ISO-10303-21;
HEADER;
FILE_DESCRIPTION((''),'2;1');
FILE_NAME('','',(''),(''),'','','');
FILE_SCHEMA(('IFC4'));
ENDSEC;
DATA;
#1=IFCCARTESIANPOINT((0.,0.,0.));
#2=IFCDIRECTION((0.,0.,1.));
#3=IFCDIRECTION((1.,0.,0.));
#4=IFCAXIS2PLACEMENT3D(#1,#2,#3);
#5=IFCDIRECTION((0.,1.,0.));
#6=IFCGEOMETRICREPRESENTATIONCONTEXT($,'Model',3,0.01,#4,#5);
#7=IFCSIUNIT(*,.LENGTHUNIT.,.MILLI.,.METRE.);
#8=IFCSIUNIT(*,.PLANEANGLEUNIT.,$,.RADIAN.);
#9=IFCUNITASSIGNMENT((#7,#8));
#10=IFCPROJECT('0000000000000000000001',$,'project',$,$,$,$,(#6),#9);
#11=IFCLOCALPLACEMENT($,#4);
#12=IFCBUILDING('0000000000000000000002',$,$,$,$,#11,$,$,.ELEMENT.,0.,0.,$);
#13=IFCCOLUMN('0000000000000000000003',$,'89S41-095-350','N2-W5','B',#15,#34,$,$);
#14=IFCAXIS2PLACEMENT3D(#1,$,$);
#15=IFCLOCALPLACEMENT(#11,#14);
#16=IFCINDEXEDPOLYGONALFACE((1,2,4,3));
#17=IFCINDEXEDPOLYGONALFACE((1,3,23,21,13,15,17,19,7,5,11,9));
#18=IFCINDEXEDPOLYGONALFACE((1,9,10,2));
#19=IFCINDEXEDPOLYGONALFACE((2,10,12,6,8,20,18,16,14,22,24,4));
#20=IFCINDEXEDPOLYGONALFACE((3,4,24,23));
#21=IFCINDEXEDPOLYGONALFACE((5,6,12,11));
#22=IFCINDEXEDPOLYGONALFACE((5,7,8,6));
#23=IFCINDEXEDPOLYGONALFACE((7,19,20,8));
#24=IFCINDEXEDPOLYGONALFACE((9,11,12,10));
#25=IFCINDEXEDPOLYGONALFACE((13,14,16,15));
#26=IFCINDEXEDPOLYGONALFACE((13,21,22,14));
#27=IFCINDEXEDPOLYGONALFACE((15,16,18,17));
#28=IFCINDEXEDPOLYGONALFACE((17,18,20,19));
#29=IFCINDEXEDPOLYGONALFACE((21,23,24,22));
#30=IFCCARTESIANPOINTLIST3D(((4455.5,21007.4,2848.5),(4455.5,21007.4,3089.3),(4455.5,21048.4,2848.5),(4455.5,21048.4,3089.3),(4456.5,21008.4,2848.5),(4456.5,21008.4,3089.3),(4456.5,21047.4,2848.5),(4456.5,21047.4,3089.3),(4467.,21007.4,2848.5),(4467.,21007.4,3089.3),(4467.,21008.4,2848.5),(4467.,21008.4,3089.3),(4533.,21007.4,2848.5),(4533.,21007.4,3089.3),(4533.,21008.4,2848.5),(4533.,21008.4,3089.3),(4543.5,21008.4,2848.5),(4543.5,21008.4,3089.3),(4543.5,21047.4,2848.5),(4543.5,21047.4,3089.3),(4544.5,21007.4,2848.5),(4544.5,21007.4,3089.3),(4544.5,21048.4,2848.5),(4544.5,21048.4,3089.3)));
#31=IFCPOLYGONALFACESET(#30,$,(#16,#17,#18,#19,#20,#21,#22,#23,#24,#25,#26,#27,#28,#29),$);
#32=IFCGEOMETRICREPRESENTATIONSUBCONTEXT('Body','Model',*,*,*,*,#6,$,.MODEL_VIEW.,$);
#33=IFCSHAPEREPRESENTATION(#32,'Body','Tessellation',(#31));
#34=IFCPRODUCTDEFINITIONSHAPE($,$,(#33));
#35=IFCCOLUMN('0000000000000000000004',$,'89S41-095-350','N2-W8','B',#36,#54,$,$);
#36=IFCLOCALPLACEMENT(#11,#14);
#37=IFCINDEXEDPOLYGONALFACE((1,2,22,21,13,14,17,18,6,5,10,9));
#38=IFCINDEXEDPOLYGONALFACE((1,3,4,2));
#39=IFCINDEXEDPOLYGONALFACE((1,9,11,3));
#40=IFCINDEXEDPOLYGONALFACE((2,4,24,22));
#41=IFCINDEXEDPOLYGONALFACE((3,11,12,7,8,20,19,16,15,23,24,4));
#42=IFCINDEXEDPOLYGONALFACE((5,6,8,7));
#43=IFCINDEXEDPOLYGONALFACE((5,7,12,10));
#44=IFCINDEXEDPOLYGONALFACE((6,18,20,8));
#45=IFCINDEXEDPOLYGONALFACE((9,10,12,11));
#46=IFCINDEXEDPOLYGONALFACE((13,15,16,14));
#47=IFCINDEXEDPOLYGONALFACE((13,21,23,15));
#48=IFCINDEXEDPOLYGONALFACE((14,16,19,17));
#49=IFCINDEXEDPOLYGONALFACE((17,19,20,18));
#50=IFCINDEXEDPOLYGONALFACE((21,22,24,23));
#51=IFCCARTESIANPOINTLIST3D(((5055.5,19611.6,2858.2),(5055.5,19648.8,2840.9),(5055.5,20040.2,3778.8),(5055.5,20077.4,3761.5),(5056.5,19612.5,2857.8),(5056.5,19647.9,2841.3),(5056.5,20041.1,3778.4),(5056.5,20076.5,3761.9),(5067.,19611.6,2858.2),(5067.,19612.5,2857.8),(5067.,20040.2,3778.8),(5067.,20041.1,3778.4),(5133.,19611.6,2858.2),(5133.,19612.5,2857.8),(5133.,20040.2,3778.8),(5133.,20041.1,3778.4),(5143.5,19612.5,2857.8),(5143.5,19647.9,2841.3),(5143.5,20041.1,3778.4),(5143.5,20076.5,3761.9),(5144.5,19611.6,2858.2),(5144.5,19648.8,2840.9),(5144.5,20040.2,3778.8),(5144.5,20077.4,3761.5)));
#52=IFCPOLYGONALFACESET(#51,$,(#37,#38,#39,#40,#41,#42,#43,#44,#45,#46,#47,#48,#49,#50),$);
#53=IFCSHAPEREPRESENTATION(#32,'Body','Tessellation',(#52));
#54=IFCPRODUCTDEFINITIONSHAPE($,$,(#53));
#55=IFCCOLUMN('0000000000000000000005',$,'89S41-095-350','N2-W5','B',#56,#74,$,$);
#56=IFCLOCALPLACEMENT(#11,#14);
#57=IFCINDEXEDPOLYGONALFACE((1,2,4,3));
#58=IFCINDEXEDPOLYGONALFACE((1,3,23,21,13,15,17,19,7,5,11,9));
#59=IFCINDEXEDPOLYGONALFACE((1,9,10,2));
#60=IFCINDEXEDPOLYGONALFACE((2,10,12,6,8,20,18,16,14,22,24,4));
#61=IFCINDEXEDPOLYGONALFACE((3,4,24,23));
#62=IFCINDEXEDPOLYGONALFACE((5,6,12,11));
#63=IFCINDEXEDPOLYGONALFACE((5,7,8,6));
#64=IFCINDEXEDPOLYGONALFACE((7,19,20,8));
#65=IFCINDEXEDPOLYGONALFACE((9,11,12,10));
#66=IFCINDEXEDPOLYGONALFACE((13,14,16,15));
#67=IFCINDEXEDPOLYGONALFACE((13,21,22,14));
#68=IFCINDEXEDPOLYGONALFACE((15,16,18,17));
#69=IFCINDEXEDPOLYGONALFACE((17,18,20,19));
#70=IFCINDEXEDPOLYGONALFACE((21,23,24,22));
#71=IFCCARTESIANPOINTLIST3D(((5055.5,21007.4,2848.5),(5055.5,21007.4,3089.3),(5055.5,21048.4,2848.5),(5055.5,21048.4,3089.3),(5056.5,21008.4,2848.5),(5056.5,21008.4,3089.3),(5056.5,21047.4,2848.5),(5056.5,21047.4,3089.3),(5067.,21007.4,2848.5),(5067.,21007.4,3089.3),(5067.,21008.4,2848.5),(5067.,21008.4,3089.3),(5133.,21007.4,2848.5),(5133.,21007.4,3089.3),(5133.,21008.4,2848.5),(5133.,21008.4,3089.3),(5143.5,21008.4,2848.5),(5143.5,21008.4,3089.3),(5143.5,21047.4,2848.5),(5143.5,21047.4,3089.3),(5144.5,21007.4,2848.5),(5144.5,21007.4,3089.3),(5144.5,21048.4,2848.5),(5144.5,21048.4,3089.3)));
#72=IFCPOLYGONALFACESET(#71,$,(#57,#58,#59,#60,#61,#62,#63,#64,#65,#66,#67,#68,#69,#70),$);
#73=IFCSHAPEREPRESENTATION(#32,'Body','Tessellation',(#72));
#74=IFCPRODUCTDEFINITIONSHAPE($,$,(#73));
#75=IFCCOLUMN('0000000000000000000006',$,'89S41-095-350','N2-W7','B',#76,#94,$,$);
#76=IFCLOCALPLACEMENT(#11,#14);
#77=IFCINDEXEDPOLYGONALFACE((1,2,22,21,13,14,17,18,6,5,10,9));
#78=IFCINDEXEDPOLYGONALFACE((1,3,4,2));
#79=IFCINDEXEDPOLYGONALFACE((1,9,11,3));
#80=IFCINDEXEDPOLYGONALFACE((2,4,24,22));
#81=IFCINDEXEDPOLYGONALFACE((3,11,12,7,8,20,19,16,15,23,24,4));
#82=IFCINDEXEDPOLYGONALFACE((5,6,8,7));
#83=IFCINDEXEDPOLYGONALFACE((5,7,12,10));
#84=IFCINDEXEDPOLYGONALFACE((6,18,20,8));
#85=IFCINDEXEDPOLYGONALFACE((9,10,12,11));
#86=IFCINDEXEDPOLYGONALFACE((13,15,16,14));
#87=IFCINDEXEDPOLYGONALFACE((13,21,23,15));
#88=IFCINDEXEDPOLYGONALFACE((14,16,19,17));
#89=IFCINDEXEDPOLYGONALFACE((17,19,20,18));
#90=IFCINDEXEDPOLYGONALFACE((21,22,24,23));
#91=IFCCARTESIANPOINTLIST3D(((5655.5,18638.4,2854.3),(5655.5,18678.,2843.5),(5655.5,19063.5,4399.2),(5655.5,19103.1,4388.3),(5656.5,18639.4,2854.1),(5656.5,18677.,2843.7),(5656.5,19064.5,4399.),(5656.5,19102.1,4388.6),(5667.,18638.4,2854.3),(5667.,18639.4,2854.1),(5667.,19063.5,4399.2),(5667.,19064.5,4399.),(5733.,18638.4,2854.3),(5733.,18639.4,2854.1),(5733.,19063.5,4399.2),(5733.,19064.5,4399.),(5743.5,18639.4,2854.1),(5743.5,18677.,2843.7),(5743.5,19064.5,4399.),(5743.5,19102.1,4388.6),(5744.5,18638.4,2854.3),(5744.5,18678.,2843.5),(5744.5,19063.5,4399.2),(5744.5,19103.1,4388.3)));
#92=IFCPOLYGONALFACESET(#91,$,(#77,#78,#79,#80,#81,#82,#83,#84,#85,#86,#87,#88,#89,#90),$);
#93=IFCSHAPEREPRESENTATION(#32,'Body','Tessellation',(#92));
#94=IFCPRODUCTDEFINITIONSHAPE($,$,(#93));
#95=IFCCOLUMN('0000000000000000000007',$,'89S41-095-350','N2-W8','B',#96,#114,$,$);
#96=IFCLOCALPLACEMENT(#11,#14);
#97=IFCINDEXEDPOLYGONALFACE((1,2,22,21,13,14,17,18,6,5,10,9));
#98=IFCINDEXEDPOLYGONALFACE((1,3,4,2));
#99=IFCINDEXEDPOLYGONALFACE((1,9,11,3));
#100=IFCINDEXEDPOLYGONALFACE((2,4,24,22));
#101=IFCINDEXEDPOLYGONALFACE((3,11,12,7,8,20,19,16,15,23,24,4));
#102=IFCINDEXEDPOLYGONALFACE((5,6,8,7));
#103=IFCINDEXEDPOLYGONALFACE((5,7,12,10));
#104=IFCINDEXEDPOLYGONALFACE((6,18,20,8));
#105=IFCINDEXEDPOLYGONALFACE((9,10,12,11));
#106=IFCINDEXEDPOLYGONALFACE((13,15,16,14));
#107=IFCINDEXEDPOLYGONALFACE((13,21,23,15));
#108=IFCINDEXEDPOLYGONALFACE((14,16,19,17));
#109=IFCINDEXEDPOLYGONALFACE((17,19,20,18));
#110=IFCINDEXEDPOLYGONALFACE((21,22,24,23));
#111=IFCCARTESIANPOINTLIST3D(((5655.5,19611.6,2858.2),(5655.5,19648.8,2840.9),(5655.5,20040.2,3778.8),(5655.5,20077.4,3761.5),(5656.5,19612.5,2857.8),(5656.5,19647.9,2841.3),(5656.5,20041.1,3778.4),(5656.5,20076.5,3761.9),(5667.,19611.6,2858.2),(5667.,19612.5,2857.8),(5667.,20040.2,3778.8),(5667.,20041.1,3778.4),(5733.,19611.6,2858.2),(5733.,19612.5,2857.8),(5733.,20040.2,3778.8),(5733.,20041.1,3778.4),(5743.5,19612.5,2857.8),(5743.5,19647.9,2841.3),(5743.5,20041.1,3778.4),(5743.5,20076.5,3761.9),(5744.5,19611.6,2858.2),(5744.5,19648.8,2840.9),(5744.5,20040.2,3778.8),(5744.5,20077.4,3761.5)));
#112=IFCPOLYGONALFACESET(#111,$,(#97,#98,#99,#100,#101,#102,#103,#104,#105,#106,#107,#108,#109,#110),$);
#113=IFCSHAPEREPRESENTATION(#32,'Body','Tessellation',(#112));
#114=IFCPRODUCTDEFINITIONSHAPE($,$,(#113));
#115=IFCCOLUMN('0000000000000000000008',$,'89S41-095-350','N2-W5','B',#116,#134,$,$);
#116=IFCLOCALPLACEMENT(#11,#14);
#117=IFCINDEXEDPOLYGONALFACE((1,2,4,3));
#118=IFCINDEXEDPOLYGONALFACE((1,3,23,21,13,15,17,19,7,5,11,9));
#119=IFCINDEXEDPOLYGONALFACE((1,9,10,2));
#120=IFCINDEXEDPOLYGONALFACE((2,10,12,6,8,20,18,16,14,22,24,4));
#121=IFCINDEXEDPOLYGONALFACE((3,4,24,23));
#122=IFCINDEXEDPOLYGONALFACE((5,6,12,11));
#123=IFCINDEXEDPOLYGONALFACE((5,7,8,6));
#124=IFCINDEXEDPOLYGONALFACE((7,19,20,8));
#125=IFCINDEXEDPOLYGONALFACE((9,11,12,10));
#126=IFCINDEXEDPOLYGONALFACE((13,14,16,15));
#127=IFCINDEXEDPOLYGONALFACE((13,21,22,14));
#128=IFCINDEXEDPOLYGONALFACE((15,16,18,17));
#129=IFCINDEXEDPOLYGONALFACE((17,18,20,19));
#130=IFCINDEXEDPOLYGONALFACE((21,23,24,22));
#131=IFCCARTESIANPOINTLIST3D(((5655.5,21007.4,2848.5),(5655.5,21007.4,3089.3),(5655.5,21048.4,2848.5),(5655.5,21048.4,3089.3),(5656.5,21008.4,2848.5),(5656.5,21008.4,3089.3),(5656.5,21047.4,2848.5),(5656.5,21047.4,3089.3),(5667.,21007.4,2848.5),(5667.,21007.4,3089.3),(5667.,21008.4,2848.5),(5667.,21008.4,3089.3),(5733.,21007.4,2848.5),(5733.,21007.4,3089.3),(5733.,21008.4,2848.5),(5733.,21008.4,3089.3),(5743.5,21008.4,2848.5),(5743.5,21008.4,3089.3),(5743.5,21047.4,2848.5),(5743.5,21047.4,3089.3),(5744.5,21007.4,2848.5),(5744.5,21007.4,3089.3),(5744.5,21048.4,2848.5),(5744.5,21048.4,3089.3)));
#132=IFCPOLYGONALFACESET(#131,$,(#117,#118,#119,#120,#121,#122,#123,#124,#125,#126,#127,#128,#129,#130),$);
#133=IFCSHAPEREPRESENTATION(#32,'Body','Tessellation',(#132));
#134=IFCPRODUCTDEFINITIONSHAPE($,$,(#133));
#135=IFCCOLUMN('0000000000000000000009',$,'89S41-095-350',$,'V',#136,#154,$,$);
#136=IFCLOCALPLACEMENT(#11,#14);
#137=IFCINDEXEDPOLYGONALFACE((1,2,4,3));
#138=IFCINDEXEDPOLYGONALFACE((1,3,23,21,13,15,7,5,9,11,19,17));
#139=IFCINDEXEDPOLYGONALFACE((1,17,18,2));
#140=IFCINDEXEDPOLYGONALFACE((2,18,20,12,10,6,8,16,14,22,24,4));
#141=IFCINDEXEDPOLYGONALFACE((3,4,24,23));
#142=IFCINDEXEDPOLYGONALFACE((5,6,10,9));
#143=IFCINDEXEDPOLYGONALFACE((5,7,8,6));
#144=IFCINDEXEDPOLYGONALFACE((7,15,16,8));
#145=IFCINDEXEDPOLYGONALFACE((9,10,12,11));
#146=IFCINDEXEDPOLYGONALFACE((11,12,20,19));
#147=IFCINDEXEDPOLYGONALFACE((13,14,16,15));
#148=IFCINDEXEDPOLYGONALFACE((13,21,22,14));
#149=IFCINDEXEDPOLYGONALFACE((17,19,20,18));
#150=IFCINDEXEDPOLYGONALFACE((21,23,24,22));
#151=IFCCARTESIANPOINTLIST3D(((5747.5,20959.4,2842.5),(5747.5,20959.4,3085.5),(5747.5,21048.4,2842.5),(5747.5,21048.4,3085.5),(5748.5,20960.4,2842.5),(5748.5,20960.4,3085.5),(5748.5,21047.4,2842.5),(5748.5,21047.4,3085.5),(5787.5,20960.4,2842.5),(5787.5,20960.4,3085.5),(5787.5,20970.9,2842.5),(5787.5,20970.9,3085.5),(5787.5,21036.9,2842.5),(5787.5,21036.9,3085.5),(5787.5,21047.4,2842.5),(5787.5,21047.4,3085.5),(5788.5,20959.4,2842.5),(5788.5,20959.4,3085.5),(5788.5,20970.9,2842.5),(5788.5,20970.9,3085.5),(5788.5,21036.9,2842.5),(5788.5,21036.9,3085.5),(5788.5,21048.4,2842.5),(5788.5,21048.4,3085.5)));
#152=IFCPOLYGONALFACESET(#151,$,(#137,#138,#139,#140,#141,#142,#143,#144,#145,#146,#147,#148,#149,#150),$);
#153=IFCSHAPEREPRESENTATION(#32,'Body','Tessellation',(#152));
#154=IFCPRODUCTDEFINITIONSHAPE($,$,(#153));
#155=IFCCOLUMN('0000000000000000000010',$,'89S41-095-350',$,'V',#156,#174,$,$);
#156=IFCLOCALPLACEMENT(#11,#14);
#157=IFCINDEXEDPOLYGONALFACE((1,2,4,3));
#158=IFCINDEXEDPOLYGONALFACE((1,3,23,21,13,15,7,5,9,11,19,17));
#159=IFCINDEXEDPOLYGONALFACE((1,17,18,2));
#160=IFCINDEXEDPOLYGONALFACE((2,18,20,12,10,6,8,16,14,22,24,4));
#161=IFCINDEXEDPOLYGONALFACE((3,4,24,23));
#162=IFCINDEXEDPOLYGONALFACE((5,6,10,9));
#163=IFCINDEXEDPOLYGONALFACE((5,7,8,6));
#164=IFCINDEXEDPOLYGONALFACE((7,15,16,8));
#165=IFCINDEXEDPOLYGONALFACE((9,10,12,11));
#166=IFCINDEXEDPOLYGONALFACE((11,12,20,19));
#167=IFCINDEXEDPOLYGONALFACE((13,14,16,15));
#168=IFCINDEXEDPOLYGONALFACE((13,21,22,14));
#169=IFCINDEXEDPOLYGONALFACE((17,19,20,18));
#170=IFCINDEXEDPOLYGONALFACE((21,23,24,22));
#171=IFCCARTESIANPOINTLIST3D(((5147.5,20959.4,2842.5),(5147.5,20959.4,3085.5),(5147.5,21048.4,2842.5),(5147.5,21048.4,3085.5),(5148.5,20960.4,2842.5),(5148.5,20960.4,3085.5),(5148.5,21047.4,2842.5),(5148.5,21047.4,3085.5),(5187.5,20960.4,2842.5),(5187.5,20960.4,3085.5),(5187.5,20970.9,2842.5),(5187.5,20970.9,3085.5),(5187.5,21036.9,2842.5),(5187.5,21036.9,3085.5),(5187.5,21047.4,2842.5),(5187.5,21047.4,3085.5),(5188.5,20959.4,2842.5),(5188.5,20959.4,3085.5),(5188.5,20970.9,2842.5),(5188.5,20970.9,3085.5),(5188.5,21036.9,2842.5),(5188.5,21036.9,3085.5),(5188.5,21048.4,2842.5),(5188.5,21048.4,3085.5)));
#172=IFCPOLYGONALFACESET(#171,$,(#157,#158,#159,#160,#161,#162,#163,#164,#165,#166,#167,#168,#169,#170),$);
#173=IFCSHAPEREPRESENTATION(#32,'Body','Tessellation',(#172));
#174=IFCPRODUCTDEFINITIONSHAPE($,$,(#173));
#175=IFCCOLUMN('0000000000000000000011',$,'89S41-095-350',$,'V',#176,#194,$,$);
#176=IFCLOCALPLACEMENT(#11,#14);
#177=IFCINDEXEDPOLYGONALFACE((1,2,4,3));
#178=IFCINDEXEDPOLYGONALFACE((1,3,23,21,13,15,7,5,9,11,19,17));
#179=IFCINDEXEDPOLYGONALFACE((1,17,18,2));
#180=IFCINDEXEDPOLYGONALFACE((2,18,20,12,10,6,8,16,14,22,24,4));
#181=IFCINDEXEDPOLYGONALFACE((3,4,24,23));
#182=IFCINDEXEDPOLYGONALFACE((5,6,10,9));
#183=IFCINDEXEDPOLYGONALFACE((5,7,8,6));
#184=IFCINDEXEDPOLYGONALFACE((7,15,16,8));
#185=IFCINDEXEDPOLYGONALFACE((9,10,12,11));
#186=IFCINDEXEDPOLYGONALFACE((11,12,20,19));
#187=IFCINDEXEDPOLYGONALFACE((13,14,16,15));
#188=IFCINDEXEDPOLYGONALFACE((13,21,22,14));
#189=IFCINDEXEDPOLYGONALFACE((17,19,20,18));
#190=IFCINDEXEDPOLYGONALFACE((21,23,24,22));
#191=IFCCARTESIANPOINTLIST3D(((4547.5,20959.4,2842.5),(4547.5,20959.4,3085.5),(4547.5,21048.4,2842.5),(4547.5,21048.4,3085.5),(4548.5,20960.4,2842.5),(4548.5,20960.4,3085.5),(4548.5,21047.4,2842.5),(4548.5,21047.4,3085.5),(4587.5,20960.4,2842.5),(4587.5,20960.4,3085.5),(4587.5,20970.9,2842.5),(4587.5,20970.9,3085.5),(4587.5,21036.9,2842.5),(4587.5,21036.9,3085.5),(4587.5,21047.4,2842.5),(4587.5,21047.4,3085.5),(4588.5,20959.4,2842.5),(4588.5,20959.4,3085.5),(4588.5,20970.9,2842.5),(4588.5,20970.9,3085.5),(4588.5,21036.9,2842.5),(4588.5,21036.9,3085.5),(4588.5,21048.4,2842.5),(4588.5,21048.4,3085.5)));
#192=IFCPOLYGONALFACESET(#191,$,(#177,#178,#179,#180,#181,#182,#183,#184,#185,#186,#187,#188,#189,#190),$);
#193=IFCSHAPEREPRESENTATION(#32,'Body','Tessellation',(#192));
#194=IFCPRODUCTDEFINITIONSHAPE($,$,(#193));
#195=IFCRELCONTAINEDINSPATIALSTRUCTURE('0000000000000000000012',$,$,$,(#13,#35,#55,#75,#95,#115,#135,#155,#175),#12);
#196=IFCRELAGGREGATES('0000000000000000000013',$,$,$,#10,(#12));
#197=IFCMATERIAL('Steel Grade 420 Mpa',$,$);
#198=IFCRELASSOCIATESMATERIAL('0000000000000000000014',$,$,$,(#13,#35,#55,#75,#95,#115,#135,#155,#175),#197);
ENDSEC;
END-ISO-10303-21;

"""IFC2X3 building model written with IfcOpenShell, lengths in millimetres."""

from ifc_helpers import new_model, si_unit, direction, frame, origin, origin_with_axes, origin_2d_with_axis, place, context, subcontext, project, spatial, c_section, extrude, source, transform, mapped, material, element, save


model = new_model("IFC2X3")

# Units and contexts
model_context = context("Model", 3, precision=0.01, world=origin_with_axes(), true_north=direction((0.0, 1.0, 0.0)))
body_context = subcontext(model_context, "Body", "Model", "MODEL_VIEW")
ifc_project = project(units=[si_unit("LENGTHUNIT", "METRE", prefix="MILLI"), si_unit("PLANEANGLEUNIT", "RADIAN")], contexts=[model_context])

# Building
building_placement = place(None, origin_with_axes())
building = spatial("IfcBuilding", under=ifc_project, at=building_placement, CompositionType="ELEMENT", ElevationOfRefHeight=0.0, ElevationOfTerrain=0.0)

# Columns
ifc_material = material(Name="Steel Grade 420 Mpa")
shared_shape_1 = source(origin(), body_context, "Body", "SweptSolid", [
    extrude(c_section(Depth=89.0, Width=41.0, WallThickness=1.0, Girth=11.5, at=origin_2d_with_axis()), origin_with_axes(), (0.0, 0.0, 1.0), 240.8),
])
column_1_placement = place(None, frame((4500.0, 21027.9, 3089.3), z_axis=(0.0, 0.0, -1.0), x_axis=(0.0, -1.0, 0.0)))
element("IfcColumn", 1, at=column_1_placement, inside=building, material=ifc_material, Name="89S41-095-350", Description="N2-W5", ObjectType="B", context=body_context, shape_type="MappedRepresentation", body=[
    mapped(shared_shape_1, transform((0.0, 0.0, 0.0), scale=1.0)),
])
shared_shape_2 = source(origin(), body_context, "Body", "SweptSolid", [
    extrude(c_section(Depth=89.0, Width=41.0, WallThickness=1.0, Girth=11.5, at=origin_2d_with_axis()), origin_with_axes(), (0.0, 0.0, 1.0), 1015.5),
])
column_2_placement = place(None, frame((5100.0, 20058.8, 3770.1), z_axis=(0.0, -0.422026, -0.906584), x_axis=(0.0, -0.906584, 0.422026)))
element("IfcColumn", 2, at=column_2_placement, inside=building, material=ifc_material, Name="89S41-095-350", Description="N2-W8", ObjectType="B", context=body_context, shape_type="MappedRepresentation", body=[
    mapped(shared_shape_2, transform((0.0, 0.0, 0.0), scale=1.0)),
])
shared_shape_3 = source(origin(), body_context, "Body", "SweptSolid", [
    extrude(c_section(Depth=89.0, Width=41.0, WallThickness=1.0, Girth=11.5, at=origin_2d_with_axis()), origin_with_axes(), (0.0, 0.0, 1.0), 240.8),
])
column_3_placement = place(None, frame((5100.0, 21027.9, 3089.3), z_axis=(0.0, 0.0, -1.0), x_axis=(0.0, -1.0, 0.0)))
element("IfcColumn", 3, at=column_3_placement, inside=building, material=ifc_material, Name="89S41-095-350", Description="N2-W5", ObjectType="B", context=body_context, shape_type="MappedRepresentation", body=[
    mapped(shared_shape_3, transform((0.0, 0.0, 0.0), scale=1.0)),
])
shared_shape_4 = source(origin(), body_context, "Body", "SweptSolid", [
    extrude(c_section(Depth=89.0, Width=41.0, WallThickness=1.0, Girth=11.5, at=origin_2d_with_axis()), origin_with_axes(), (0.0, 0.0, 1.0), 1602.3),
])
column_4_placement = place(None, frame((5700.0, 19083.3, 4393.8), z_axis=(0.0, -0.265305, -0.964165), x_axis=(0.0, -0.964165, 0.265305)))
element("IfcColumn", 4, at=column_4_placement, inside=building, material=ifc_material, Name="89S41-095-350", Description="N2-W7", ObjectType="B", context=body_context, shape_type="MappedRepresentation", body=[
    mapped(shared_shape_4, transform((0.0, 0.0, 0.0), scale=1.0)),
])
shared_shape_5 = source(origin(), body_context, "Body", "SweptSolid", [
    extrude(c_section(Depth=89.0, Width=41.0, WallThickness=1.0, Girth=11.5, at=origin_2d_with_axis()), origin_with_axes(), (0.0, 0.0, 1.0), 1015.5),
])
column_5_placement = place(None, frame((5700.0, 20058.8, 3770.1), z_axis=(0.0, -0.422026, -0.906584), x_axis=(0.0, -0.906584, 0.422026)))
element("IfcColumn", 5, at=column_5_placement, inside=building, material=ifc_material, Name="89S41-095-350", Description="N2-W8", ObjectType="B", context=body_context, shape_type="MappedRepresentation", body=[
    mapped(shared_shape_5, transform((0.0, 0.0, 0.0), scale=1.0)),
])
shared_shape_6 = source(origin(), body_context, "Body", "SweptSolid", [
    extrude(c_section(Depth=89.0, Width=41.0, WallThickness=1.0, Girth=11.5, at=origin_2d_with_axis()), origin_with_axes(), (0.0, 0.0, 1.0), 240.8),
])
column_6_placement = place(None, frame((5700.0, 21027.9, 3089.3), z_axis=(0.0, 0.0, -1.0), x_axis=(0.0, -1.0, 0.0)))
element("IfcColumn", 6, at=column_6_placement, inside=building, material=ifc_material, Name="89S41-095-350", Description="N2-W5", ObjectType="B", context=body_context, shape_type="MappedRepresentation", body=[
    mapped(shared_shape_6, transform((0.0, 0.0, 0.0), scale=1.0)),
])
shared_shape_7 = source(origin(), body_context, "Body", "SweptSolid", [
    extrude(c_section(Depth=89.0, Width=41.0, WallThickness=1.0, Girth=11.5, at=origin_2d_with_axis()), origin_with_axes(), (0.0, 0.0, 1.0), 243.0),
])
column_7_placement = place(None, frame((5768.0, 21003.9, 3085.5), z_axis=(0.0, 0.0, -1.0), x_axis=(1.0, 0.0, 0.0)))
element("IfcColumn", 7, at=column_7_placement, inside=building, material=ifc_material, Name="89S41-095-350", ObjectType="V", context=body_context, shape_type="MappedRepresentation", body=[
    mapped(shared_shape_7, transform((0.0, 0.0, 0.0), scale=1.0)),
])
shared_shape_8 = source(origin(), body_context, "Body", "SweptSolid", [
    extrude(c_section(Depth=89.0, Width=41.0, WallThickness=1.0, Girth=11.5, at=origin_2d_with_axis()), origin_with_axes(), (0.0, 0.0, 1.0), 243.0),
])
column_8_placement = place(None, frame((5168.0, 21003.9, 3085.5), z_axis=(0.0, 0.0, -1.0), x_axis=(1.0, 0.0, 0.0)))
element("IfcColumn", 8, at=column_8_placement, inside=building, material=ifc_material, Name="89S41-095-350", ObjectType="V", context=body_context, shape_type="MappedRepresentation", body=[
    mapped(shared_shape_8, transform((0.0, 0.0, 0.0), scale=1.0)),
])
shared_shape_9 = source(origin(), body_context, "Body", "SweptSolid", [
    extrude(c_section(Depth=89.0, Width=41.0, WallThickness=1.0, Girth=11.5, at=origin_2d_with_axis()), origin_with_axes(), (0.0, 0.0, 1.0), 243.0),
])
column_9_placement = place(None, frame((4568.0, 21003.9, 3085.5), z_axis=(0.0, 0.0, -1.0), x_axis=(1.0, 0.0, 0.0)))
element("IfcColumn", 9, at=column_9_placement, inside=building, material=ifc_material, Name="89S41-095-350", ObjectType="V", context=body_context, shape_type="MappedRepresentation", body=[
    mapped(shared_shape_9, transform((0.0, 0.0, 0.0), scale=1.0)),
])

save(model, "model.ifc")
